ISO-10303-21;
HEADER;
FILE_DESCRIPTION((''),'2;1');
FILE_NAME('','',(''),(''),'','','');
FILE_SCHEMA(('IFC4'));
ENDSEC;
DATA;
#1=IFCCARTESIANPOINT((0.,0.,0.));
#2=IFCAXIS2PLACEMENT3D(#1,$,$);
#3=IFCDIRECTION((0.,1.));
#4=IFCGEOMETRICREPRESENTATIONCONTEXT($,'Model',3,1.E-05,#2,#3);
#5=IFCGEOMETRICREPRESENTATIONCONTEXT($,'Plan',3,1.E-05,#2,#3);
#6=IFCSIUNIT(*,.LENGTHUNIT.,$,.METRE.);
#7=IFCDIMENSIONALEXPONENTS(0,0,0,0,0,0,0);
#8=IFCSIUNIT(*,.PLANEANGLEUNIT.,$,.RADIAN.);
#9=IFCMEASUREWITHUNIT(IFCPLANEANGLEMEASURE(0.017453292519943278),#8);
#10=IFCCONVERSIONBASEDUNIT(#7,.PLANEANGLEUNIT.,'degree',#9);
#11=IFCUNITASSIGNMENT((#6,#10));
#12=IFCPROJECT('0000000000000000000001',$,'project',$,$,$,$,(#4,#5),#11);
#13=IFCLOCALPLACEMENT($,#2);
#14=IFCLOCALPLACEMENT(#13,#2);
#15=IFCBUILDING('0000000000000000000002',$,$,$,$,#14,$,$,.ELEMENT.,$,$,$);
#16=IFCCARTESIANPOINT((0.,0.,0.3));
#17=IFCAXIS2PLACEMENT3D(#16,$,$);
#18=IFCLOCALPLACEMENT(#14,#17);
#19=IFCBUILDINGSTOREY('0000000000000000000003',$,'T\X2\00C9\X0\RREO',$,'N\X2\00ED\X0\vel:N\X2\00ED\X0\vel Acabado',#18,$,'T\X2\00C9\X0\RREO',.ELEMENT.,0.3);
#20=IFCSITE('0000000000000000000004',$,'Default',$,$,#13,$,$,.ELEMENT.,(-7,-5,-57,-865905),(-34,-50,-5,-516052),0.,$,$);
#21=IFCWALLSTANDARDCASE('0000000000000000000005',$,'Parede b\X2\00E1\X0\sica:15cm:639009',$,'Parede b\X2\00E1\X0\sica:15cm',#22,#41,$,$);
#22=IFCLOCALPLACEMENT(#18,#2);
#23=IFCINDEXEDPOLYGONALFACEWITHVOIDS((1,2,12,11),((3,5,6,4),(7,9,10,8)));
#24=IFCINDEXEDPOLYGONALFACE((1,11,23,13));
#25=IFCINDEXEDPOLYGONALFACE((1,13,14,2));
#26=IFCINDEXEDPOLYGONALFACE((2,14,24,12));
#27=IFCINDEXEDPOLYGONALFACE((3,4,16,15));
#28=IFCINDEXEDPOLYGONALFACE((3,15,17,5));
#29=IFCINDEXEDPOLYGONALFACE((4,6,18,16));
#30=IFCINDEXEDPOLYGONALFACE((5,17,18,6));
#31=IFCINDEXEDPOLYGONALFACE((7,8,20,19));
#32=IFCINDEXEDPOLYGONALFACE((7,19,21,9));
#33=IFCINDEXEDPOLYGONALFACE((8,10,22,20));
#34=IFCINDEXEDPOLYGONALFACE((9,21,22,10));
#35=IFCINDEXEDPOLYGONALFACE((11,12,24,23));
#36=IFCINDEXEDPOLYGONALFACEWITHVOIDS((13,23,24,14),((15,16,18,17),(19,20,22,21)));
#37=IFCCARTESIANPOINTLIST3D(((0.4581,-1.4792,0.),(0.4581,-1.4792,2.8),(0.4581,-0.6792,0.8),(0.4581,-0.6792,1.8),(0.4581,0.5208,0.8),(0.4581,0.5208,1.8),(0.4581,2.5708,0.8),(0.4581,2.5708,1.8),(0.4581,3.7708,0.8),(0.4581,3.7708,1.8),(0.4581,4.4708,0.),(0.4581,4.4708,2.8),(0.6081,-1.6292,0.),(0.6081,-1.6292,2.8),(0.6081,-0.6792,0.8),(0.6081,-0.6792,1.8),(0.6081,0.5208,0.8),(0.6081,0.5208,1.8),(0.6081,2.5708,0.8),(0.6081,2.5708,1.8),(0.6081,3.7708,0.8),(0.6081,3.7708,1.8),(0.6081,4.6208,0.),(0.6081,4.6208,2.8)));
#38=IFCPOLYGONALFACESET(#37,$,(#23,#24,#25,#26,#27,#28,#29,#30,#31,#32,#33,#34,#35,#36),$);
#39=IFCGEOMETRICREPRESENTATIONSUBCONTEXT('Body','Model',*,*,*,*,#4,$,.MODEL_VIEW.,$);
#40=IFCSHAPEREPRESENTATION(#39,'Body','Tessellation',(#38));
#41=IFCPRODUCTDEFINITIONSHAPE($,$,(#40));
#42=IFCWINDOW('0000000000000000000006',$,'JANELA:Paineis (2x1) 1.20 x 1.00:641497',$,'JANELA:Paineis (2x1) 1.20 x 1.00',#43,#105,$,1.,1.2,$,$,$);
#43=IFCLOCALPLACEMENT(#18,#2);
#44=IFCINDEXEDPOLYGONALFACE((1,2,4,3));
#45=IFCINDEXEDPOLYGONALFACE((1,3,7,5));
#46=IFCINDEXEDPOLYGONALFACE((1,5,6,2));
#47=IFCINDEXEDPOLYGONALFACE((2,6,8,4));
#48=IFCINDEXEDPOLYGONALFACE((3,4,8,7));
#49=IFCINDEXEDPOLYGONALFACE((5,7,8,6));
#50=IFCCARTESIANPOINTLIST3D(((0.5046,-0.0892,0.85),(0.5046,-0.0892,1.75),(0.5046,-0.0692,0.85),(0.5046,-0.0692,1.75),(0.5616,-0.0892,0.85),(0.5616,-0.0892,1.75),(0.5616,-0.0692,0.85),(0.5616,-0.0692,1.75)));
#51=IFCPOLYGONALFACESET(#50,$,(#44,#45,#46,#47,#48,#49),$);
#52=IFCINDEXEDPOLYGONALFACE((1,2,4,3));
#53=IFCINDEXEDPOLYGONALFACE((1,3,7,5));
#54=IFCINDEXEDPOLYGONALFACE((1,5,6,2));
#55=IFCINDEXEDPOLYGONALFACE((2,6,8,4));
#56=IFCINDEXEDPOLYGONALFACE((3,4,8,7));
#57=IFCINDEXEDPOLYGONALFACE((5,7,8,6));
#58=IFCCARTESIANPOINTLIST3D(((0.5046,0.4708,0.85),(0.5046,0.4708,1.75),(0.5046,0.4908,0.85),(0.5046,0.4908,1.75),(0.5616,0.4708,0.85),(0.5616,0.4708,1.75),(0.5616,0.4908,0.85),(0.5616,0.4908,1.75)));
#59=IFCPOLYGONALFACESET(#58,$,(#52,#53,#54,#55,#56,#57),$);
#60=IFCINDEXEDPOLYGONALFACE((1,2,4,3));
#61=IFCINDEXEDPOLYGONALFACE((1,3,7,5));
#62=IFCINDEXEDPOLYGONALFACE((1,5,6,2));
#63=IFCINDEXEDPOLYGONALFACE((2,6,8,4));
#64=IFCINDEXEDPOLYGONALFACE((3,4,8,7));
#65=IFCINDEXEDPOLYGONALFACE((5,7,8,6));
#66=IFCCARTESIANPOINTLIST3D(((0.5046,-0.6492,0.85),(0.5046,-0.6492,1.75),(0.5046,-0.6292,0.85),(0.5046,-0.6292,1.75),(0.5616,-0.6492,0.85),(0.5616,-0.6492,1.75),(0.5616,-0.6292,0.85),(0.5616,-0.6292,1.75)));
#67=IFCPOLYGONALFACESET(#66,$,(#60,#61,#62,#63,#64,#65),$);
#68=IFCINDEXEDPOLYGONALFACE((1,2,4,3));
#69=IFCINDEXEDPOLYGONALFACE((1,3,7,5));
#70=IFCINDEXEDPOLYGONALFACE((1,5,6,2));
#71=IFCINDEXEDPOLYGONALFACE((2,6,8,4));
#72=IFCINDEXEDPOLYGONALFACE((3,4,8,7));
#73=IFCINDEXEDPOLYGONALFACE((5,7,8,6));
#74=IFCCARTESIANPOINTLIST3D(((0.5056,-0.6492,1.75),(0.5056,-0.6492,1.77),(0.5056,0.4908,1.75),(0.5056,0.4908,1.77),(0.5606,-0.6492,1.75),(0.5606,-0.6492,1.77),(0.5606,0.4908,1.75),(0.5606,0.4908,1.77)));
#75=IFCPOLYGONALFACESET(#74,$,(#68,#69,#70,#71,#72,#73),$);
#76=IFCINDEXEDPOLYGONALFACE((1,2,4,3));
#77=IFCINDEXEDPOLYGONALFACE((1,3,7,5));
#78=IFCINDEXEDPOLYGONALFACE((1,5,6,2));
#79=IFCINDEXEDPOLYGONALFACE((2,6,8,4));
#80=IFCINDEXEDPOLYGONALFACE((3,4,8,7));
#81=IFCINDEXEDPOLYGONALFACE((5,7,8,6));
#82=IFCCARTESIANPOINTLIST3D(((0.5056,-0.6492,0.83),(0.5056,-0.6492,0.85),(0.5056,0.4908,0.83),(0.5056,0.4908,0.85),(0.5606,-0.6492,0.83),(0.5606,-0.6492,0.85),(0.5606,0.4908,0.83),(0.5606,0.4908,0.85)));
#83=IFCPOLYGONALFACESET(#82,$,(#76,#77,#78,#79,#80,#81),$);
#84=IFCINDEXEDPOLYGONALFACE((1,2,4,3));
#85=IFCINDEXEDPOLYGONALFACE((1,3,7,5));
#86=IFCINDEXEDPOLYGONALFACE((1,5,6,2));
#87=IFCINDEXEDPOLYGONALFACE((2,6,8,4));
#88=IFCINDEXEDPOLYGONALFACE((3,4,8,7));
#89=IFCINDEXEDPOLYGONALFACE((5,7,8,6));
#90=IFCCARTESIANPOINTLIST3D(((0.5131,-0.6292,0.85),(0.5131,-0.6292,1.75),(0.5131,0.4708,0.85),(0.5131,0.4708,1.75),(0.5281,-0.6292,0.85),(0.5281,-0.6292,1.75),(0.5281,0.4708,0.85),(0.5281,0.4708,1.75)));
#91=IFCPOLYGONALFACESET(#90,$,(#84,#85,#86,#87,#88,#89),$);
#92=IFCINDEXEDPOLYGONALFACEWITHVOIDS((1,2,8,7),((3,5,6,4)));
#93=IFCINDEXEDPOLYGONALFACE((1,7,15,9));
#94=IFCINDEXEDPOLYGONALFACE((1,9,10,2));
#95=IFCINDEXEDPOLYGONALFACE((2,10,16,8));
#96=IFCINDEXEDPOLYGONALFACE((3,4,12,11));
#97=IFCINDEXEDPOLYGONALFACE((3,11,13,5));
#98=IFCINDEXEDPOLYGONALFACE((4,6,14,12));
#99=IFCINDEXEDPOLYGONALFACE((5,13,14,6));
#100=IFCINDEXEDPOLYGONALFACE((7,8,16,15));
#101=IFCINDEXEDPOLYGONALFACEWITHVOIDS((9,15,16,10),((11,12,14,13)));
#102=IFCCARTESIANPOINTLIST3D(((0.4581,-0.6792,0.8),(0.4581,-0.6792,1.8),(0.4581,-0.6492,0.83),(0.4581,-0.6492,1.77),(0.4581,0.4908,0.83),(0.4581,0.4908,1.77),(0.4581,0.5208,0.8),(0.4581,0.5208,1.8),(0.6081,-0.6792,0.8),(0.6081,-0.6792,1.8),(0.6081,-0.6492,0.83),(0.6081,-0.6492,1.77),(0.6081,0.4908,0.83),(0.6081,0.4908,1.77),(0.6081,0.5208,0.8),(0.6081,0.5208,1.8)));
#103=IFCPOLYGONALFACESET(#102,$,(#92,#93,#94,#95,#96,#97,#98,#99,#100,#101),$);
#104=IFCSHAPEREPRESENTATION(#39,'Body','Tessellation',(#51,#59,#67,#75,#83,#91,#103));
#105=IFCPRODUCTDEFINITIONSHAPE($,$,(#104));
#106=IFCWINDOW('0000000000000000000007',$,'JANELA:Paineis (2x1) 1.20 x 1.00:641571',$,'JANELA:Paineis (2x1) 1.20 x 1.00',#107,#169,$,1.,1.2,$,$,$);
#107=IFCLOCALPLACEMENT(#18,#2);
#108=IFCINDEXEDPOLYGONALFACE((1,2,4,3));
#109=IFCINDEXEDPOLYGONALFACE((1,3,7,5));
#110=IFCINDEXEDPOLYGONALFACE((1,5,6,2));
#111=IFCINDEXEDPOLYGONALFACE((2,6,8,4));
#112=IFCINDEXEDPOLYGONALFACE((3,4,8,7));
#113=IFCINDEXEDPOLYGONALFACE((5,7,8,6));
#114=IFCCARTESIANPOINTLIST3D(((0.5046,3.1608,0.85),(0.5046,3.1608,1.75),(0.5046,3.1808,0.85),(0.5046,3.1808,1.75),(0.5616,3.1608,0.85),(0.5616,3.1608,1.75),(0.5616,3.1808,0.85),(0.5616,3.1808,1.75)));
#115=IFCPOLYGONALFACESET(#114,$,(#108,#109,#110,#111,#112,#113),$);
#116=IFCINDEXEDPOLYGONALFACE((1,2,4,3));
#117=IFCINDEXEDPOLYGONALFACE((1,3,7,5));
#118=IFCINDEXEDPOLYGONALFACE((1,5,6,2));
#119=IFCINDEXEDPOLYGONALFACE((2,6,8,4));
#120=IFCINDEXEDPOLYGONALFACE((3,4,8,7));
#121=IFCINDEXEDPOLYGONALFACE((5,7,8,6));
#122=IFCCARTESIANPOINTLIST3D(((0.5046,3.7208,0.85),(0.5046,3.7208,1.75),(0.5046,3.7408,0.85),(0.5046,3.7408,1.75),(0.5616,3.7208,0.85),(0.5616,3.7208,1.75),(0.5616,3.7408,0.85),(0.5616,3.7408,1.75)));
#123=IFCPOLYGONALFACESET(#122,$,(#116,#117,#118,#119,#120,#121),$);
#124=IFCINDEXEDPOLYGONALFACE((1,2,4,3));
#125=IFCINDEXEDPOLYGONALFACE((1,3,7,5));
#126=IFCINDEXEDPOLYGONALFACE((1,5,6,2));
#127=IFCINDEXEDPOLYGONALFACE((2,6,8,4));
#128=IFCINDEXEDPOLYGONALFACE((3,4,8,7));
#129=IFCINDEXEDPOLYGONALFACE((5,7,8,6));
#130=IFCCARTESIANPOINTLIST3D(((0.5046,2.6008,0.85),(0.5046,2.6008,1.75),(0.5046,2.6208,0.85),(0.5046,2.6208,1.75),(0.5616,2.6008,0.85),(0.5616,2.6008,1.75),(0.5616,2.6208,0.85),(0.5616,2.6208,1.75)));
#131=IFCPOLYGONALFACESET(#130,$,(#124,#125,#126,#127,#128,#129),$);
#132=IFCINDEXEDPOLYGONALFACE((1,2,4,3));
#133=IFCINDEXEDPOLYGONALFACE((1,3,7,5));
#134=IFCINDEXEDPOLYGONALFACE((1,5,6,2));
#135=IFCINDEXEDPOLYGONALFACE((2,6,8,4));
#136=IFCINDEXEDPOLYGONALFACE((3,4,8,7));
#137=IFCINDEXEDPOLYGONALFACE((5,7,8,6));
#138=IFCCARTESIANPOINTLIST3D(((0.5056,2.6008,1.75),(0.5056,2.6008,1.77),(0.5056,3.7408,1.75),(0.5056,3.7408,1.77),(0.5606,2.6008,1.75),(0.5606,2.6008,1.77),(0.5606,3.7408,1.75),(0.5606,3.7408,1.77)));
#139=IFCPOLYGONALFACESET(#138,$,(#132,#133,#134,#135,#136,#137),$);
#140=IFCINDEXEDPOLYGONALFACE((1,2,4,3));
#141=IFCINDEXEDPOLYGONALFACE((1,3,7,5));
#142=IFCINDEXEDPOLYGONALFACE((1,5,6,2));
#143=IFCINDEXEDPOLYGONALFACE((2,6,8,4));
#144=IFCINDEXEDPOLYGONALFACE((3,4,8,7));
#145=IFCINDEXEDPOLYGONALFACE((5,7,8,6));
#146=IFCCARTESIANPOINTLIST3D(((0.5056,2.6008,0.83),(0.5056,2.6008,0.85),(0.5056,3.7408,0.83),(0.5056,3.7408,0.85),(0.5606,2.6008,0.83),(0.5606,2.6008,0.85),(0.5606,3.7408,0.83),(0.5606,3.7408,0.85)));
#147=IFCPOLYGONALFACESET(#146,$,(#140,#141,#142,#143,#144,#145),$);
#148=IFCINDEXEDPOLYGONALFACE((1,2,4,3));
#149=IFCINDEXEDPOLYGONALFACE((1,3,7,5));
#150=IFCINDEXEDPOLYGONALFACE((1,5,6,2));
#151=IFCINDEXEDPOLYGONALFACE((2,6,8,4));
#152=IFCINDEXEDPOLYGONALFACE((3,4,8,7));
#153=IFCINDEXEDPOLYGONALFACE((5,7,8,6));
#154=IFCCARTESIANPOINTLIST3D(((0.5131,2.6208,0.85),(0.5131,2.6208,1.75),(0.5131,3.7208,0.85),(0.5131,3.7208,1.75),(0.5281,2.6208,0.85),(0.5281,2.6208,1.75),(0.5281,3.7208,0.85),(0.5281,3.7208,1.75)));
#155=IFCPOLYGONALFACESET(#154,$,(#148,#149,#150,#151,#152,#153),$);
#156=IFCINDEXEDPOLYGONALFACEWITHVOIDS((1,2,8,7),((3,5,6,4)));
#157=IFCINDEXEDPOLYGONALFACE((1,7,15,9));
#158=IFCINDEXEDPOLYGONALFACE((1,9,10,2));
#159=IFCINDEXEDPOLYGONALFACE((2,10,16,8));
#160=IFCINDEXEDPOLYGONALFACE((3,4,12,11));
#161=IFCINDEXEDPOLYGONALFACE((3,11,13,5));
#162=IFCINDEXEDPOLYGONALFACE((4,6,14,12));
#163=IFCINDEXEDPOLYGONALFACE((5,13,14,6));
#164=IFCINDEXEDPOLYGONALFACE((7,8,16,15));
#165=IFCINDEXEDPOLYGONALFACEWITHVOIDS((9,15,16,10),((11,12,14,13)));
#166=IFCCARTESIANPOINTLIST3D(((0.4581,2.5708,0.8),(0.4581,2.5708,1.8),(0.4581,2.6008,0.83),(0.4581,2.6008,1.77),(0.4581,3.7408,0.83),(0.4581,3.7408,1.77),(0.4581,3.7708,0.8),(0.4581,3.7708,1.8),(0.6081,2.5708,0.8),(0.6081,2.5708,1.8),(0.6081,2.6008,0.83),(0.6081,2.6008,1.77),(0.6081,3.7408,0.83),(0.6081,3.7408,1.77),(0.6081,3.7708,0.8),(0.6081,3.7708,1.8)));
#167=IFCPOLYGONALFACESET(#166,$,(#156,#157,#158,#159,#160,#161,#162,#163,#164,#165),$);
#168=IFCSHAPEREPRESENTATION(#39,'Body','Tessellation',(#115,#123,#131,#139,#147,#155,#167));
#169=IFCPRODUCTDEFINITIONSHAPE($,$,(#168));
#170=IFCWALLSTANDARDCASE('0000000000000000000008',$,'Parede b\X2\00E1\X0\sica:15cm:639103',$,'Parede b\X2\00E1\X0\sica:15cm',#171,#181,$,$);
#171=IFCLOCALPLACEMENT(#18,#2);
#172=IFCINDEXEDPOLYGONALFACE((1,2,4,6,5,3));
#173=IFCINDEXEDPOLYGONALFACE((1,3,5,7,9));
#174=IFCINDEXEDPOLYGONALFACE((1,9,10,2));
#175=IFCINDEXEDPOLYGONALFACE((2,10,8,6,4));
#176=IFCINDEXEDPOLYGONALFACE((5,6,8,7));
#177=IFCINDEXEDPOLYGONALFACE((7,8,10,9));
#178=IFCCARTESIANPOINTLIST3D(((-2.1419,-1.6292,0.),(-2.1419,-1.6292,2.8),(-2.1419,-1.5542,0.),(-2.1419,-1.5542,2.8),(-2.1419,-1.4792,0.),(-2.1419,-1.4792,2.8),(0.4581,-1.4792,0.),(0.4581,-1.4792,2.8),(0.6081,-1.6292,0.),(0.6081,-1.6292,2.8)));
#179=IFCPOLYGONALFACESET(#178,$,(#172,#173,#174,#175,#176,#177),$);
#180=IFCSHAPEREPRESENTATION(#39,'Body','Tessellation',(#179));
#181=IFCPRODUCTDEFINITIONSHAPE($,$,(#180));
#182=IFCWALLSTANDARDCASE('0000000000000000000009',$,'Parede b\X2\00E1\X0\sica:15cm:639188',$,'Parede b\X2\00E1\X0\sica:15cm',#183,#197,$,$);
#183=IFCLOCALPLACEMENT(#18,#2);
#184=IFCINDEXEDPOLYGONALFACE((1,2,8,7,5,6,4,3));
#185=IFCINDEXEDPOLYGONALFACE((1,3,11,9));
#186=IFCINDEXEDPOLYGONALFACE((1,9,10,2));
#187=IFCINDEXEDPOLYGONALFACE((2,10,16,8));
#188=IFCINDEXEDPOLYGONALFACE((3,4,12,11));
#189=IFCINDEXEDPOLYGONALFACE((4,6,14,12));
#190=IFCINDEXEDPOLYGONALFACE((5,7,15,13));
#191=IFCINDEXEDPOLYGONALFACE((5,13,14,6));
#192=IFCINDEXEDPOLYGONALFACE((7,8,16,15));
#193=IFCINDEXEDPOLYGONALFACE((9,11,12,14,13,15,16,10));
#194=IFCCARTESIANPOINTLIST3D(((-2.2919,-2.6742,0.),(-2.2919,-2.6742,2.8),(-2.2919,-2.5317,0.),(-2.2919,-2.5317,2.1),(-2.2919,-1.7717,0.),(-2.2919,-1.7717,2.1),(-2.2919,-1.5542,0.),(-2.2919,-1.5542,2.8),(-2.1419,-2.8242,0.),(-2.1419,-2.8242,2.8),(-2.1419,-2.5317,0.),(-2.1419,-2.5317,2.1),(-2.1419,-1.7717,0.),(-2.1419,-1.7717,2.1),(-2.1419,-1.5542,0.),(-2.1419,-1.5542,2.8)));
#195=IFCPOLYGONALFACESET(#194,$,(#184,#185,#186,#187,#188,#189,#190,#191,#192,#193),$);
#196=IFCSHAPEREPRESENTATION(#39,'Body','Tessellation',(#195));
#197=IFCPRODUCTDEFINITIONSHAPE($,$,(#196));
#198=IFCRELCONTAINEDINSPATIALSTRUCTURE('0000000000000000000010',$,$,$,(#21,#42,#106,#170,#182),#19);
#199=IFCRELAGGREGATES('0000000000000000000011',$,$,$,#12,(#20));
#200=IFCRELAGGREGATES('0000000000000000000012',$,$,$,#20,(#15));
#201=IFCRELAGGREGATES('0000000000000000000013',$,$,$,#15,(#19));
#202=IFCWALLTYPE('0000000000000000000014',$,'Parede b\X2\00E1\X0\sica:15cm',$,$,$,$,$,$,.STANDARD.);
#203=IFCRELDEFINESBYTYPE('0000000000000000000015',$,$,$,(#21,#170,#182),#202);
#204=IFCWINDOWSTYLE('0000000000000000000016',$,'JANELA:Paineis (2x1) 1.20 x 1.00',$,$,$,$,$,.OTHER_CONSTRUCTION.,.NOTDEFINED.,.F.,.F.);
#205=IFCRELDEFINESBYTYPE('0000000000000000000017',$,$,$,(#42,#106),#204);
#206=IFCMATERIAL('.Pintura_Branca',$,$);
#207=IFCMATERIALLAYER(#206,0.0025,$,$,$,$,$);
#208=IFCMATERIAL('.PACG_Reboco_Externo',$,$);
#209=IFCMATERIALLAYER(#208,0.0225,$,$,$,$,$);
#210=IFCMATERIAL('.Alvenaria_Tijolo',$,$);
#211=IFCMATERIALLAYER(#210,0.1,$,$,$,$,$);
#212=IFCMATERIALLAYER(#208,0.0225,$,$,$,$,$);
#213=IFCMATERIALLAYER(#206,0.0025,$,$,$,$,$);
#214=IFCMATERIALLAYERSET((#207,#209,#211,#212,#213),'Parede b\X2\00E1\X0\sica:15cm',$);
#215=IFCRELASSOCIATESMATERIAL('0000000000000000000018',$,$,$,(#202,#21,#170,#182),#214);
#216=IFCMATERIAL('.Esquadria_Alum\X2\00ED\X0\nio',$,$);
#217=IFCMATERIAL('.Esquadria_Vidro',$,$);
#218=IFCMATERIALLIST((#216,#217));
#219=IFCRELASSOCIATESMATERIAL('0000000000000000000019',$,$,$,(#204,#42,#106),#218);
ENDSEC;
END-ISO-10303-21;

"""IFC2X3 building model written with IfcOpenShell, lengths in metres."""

from ifc_helpers import new_model, entity, si_unit, converted_unit, direction, frame, frame_2d, origin, origin_2d_with_axis, place, context, subcontext, project, spatial, polyline, rectangle, outline, extrude, source, transform, mapped, material, material_list, layer, layer_set, layer_usage, type_object, type_shapes, element, fill, save


model = new_model("IFC2X3")

# Units and contexts
model_context = context("Model", 3, precision=1e-05, world=origin(), true_north=direction((0.0, 1.0)))
plan_context = context("Plan", 3, precision=1e-05, world=origin(), true_north=direction((0.0, 1.0)))
body_context = subcontext(model_context, "Body", "Model", "MODEL_VIEW")
ifc_project = project(units=[si_unit("LENGTHUNIT", "METRE"), converted_unit("PLANEANGLEUNIT", "degree", entity("IfcPlaneAngleMeasure", 0.017453292519943278), si_unit("PLANEANGLEUNIT", "RADIAN"), dimensions=[0, 0, 0, 0, 0, 0, 0])], contexts=[model_context, plan_context])

# Site, building, storey
site_placement = place(None, origin())
site = spatial("IfcSite", under=ifc_project, at=site_placement, Name="Default", CompositionType="ELEMENT", RefLatitude=(-7, -5, -57, -865905), RefLongitude=(-34, -50, -5, -516052), RefElevation=0.0)
building_placement = place(site_placement, origin())
building = spatial("IfcBuilding", under=site, at=building_placement, CompositionType="ELEMENT")
storey_placement = place(building_placement, frame((0.0, 0.0, 0.3)))
storey = spatial("IfcBuildingStorey", under=building, at=storey_placement, Name="TÉRREO", ObjectType="Nível:Nível Acabado", LongName="TÉRREO", CompositionType="ELEMENT", Elevation=0.3)

# Shared definitions
ifc_material_1 = material(Name=".Pintura_Branca")
ifc_layer_1 = layer(ifc_material_1, 0.0025)
ifc_material_2 = material(Name=".PACG_Reboco_Externo")
ifc_layer_2 = layer(ifc_material_2, 0.0225)
ifc_material_3 = material(Name=".Alvenaria_Tijolo")
ifc_layer_3 = layer(ifc_material_3, 0.1)
ifc_layer_4 = layer(ifc_material_2, 0.0225)
ifc_layer_5 = layer(ifc_material_1, 0.0025)
ifc_layer_set_1 = layer_set([ifc_layer_1, ifc_layer_2, ifc_layer_3, ifc_layer_4, ifc_layer_5], Name="Parede básica:15cm")
wall_type = type_object("IfcWallType", Name="Parede básica:15cm", PredefinedType="STANDARD", material=ifc_layer_set_1)
ifc_material_4 = material(Name=".Esquadria_Alumínio")
ifc_material_5 = material(Name=".Esquadria_Vidro")
ifc_material_list = material_list([ifc_material_4, ifc_material_5])

# Wall, openings, windows
ifc_layer_usage_1 = layer_usage(ifc_layer_set_1, "AXIS2", "NEGATIVE", 0.075)
wall_1_placement = place(storey_placement, frame((0.5331, 4.6208, 0.0), z_axis=(0.0, 0.0, 1.0), x_axis=(0.0, -1.0, 0.0)))
wall_1 = element("IfcWallStandardCase", 1, at=wall_1_placement, inside=storey, type_object=wall_type, material=ifc_layer_usage_1, Name="Parede básica:15cm:639009", ObjectType="Parede básica:15cm", context=body_context, shape_type="SweptSolid", body=[
    extrude(outline(polyline([(6.1, -0.075), (6.25, 0.075), (0.0, 0.075), (0.15, -0.075), (3.0, -0.075), (3.15, -0.075), (6.1, -0.075)])), origin(), (0.0, 0.0, 1.0), 2.8),
])
opening_1_placement = place(wall_1_placement, frame((4.1, -0.075, 0.8)))
opening_1 = element("IfcOpeningElement", 2, at=opening_1_placement, cuts=wall_1, ObjectType="Opening", context=body_context, shape_type="SweptSolid", body=[
    extrude(rectangle(XDim=1.0, YDim=1.2, at=frame_2d((0.5, 0.6), x_axis=(1.0, 0.0))), frame((0.0, 0.0, 0.0), z_axis=(0.0, 1.0, 0.0), x_axis=(0.0, 0.0, 1.0)), (0.0, 0.0, 1.0), 0.15),
])
opening_2_placement = place(wall_1_placement, frame((0.85, -0.075, 0.8)))
opening_2 = element("IfcOpeningElement", 3, at=opening_2_placement, cuts=wall_1, ObjectType="Opening", context=body_context, shape_type="SweptSolid", body=[
    extrude(rectangle(XDim=1.0, YDim=1.2, at=frame_2d((0.5, 0.6), x_axis=(1.0, 0.0))), frame((0.0, 0.0, 0.0), z_axis=(0.0, 1.0, 0.0), x_axis=(0.0, 0.0, 1.0)), (0.0, 0.0, 1.0), 0.15),
])
window_style_1 = type_object("IfcWindowStyle", Name="JANELA:Paineis (2x1) 1.20 x 1.00", ConstructionType="OTHER_CONSTRUCTION", OperationType="NOTDEFINED", ParameterTakesPrecedence=False, Sizeable=False, material=ifc_material_list)
shared_shape_1 = source(origin(), body_context, "Body", "SweptSolid", [
    extrude(rectangle(XDim=0.02, YDim=0.057, at=origin_2d_with_axis()), frame((0.6, 0.075, 0.05), z_axis=(0.0, 0.0, 1.0), x_axis=(-1.0, 0.0, 0.0)), (0.0, 0.0, 1.0), 0.9),
    extrude(rectangle(XDim=0.02, YDim=0.057, at=frame_2d((0.0, 0.0), x_axis=(1.0, 0.0))), frame((0.04, 0.075, 0.05), z_axis=(0.0, 0.0, 1.0), x_axis=(-1.0, 0.0, 0.0)), (0.0, 0.0, 1.0), 0.9),
    extrude(rectangle(XDim=0.02, YDim=0.057, at=frame_2d((0.0, 0.0), x_axis=(1.0, 0.0))), frame((1.16, 0.075, 0.05), z_axis=(0.0, 0.0, 1.0), x_axis=(-1.0, 0.0, 0.0)), (0.0, 0.0, 1.0), 0.9),
    extrude(rectangle(XDim=1.14, YDim=0.055, at=frame_2d((0.0, 0.0), x_axis=(1.0, 0.0))), frame((0.6, 0.075, 0.95), z_axis=(0.0, 0.0, 1.0), x_axis=(-1.0, 0.0, 0.0)), (0.0, 0.0, 1.0), 0.02),
    extrude(rectangle(XDim=1.14, YDim=0.055, at=frame_2d((0.0, 0.0), x_axis=(1.0, 0.0))), frame((0.6, 0.075, 0.03), z_axis=(0.0, 0.0, 1.0), x_axis=(-1.0, 0.0, 0.0)), (0.0, 0.0, 1.0), 0.02),
    extrude(rectangle(XDim=0.015, YDim=1.1, at=frame_2d((0.0, 0.0), x_axis=(1.0, 0.0))), frame((0.6, 0.0625, 0.05), z_axis=(0.0, 0.0, 1.0), x_axis=(0.0, 1.0, 0.0)), (0.0, 0.0, 1.0), 0.9),
    extrude(outline(polyline([(-0.6, -0.5), (0.6, -0.5), (0.6, 0.5), (-0.6, 0.5), (-0.6, -0.5)]), holes=[polyline([(0.57, -0.47), (-0.57, -0.47), (-0.57, 0.47), (0.57, 0.47), (0.57, -0.47)])]), frame((0.6, 0.0, 0.5), z_axis=(0.0, 1.0, 0.0), x_axis=(1.0, 0.0, 0.0)), (0.0, 0.0, 1.0), 0.15),
])
type_shapes(window_style_1, [shared_shape_1])
window_1_placement = place(opening_1_placement, origin())
window_1 = element("IfcWindow", 4, at=window_1_placement, inside=storey, type_object=window_style_1, material=ifc_material_list, Name="JANELA:Paineis (2x1) 1.20 x 1.00:641497", ObjectType="JANELA:Paineis (2x1) 1.20 x 1.00", OverallHeight=1.0, OverallWidth=1.2, context=body_context, shape_type="MappedRepresentation", body=[
    mapped(shared_shape_1, transform((0.0, 0.0, 0.0), scale=1.0)),
])
fill(opening_1, window_1)
window_2_placement = place(opening_2_placement, origin())
window_2 = element("IfcWindow", 5, at=window_2_placement, inside=storey, type_object=window_style_1, material=ifc_material_list, Name="JANELA:Paineis (2x1) 1.20 x 1.00:641571", ObjectType="JANELA:Paineis (2x1) 1.20 x 1.00", OverallHeight=1.0, OverallWidth=1.2, context=body_context, shape_type="MappedRepresentation", body=[
    mapped(shared_shape_1, transform((0.0, 0.0, 0.0), scale=1.0)),
])
fill(opening_2, window_2)

# Wall
ifc_layer_usage_2 = layer_usage(ifc_layer_set_1, "AXIS2", "NEGATIVE", 0.075)
wall_2_placement = place(storey_placement, frame((0.6081, -1.5542, 0.0), z_axis=(0.0, 0.0, 1.0), x_axis=(-1.0, 0.0, 0.0)))
element("IfcWallStandardCase", 6, at=wall_2_placement, inside=storey, type_object=wall_type, material=ifc_layer_usage_2, Name="Parede básica:15cm:639103", ObjectType="Parede básica:15cm", context=body_context, shape_type="SweptSolid", body=[
    extrude(outline(polyline([(2.75, -0.075), (2.75, 0.0), (2.75, 0.075), (0.0, 0.075), (0.15, -0.075), (2.75, -0.075)])), origin(), (0.0, 0.0, 1.0), 2.8),
])

# Wall, opening
ifc_layer_usage_3 = layer_usage(ifc_layer_set_1, "AXIS2", "NEGATIVE", 0.075)
wall_3_placement = place(storey_placement, frame((-2.2169, -1.5542, 0.0), z_axis=(0.0, 0.0, 1.0), x_axis=(0.0, -1.0, 0.0)))
wall_3 = element("IfcWallStandardCase", 7, at=wall_3_placement, inside=storey, type_object=wall_type, material=ifc_layer_usage_3, Name="Parede básica:15cm:639188", ObjectType="Parede básica:15cm", context=body_context, shape_type="SweptSolid", body=[
    extrude(outline(polyline([(0.0, -0.075), (1.12, -0.075), (1.27, 0.075), (0.075, 0.075), (0.0, 0.075), (0.0, -0.075)])), origin(), (0.0, 0.0, 1.0), 2.8),
])
opening_3_placement = place(wall_3_placement, frame((0.9775, 0.075, 0.0)))
element("IfcOpeningElement", 8, at=opening_3_placement, cuts=wall_3, ObjectType="Opening", context=body_context, shape_type="SweptSolid", body=[
    extrude(rectangle(XDim=0.76, YDim=2.1, at=frame_2d((1.05, 0.38), x_axis=(0.0, 1.0))), frame((0.0, 0.0, 0.0), z_axis=(0.0, -1.0, 0.0), x_axis=(0.0, 0.0, 1.0)), (0.0, 0.0, 1.0), 0.15),
])

save(model, "model.ifc")
